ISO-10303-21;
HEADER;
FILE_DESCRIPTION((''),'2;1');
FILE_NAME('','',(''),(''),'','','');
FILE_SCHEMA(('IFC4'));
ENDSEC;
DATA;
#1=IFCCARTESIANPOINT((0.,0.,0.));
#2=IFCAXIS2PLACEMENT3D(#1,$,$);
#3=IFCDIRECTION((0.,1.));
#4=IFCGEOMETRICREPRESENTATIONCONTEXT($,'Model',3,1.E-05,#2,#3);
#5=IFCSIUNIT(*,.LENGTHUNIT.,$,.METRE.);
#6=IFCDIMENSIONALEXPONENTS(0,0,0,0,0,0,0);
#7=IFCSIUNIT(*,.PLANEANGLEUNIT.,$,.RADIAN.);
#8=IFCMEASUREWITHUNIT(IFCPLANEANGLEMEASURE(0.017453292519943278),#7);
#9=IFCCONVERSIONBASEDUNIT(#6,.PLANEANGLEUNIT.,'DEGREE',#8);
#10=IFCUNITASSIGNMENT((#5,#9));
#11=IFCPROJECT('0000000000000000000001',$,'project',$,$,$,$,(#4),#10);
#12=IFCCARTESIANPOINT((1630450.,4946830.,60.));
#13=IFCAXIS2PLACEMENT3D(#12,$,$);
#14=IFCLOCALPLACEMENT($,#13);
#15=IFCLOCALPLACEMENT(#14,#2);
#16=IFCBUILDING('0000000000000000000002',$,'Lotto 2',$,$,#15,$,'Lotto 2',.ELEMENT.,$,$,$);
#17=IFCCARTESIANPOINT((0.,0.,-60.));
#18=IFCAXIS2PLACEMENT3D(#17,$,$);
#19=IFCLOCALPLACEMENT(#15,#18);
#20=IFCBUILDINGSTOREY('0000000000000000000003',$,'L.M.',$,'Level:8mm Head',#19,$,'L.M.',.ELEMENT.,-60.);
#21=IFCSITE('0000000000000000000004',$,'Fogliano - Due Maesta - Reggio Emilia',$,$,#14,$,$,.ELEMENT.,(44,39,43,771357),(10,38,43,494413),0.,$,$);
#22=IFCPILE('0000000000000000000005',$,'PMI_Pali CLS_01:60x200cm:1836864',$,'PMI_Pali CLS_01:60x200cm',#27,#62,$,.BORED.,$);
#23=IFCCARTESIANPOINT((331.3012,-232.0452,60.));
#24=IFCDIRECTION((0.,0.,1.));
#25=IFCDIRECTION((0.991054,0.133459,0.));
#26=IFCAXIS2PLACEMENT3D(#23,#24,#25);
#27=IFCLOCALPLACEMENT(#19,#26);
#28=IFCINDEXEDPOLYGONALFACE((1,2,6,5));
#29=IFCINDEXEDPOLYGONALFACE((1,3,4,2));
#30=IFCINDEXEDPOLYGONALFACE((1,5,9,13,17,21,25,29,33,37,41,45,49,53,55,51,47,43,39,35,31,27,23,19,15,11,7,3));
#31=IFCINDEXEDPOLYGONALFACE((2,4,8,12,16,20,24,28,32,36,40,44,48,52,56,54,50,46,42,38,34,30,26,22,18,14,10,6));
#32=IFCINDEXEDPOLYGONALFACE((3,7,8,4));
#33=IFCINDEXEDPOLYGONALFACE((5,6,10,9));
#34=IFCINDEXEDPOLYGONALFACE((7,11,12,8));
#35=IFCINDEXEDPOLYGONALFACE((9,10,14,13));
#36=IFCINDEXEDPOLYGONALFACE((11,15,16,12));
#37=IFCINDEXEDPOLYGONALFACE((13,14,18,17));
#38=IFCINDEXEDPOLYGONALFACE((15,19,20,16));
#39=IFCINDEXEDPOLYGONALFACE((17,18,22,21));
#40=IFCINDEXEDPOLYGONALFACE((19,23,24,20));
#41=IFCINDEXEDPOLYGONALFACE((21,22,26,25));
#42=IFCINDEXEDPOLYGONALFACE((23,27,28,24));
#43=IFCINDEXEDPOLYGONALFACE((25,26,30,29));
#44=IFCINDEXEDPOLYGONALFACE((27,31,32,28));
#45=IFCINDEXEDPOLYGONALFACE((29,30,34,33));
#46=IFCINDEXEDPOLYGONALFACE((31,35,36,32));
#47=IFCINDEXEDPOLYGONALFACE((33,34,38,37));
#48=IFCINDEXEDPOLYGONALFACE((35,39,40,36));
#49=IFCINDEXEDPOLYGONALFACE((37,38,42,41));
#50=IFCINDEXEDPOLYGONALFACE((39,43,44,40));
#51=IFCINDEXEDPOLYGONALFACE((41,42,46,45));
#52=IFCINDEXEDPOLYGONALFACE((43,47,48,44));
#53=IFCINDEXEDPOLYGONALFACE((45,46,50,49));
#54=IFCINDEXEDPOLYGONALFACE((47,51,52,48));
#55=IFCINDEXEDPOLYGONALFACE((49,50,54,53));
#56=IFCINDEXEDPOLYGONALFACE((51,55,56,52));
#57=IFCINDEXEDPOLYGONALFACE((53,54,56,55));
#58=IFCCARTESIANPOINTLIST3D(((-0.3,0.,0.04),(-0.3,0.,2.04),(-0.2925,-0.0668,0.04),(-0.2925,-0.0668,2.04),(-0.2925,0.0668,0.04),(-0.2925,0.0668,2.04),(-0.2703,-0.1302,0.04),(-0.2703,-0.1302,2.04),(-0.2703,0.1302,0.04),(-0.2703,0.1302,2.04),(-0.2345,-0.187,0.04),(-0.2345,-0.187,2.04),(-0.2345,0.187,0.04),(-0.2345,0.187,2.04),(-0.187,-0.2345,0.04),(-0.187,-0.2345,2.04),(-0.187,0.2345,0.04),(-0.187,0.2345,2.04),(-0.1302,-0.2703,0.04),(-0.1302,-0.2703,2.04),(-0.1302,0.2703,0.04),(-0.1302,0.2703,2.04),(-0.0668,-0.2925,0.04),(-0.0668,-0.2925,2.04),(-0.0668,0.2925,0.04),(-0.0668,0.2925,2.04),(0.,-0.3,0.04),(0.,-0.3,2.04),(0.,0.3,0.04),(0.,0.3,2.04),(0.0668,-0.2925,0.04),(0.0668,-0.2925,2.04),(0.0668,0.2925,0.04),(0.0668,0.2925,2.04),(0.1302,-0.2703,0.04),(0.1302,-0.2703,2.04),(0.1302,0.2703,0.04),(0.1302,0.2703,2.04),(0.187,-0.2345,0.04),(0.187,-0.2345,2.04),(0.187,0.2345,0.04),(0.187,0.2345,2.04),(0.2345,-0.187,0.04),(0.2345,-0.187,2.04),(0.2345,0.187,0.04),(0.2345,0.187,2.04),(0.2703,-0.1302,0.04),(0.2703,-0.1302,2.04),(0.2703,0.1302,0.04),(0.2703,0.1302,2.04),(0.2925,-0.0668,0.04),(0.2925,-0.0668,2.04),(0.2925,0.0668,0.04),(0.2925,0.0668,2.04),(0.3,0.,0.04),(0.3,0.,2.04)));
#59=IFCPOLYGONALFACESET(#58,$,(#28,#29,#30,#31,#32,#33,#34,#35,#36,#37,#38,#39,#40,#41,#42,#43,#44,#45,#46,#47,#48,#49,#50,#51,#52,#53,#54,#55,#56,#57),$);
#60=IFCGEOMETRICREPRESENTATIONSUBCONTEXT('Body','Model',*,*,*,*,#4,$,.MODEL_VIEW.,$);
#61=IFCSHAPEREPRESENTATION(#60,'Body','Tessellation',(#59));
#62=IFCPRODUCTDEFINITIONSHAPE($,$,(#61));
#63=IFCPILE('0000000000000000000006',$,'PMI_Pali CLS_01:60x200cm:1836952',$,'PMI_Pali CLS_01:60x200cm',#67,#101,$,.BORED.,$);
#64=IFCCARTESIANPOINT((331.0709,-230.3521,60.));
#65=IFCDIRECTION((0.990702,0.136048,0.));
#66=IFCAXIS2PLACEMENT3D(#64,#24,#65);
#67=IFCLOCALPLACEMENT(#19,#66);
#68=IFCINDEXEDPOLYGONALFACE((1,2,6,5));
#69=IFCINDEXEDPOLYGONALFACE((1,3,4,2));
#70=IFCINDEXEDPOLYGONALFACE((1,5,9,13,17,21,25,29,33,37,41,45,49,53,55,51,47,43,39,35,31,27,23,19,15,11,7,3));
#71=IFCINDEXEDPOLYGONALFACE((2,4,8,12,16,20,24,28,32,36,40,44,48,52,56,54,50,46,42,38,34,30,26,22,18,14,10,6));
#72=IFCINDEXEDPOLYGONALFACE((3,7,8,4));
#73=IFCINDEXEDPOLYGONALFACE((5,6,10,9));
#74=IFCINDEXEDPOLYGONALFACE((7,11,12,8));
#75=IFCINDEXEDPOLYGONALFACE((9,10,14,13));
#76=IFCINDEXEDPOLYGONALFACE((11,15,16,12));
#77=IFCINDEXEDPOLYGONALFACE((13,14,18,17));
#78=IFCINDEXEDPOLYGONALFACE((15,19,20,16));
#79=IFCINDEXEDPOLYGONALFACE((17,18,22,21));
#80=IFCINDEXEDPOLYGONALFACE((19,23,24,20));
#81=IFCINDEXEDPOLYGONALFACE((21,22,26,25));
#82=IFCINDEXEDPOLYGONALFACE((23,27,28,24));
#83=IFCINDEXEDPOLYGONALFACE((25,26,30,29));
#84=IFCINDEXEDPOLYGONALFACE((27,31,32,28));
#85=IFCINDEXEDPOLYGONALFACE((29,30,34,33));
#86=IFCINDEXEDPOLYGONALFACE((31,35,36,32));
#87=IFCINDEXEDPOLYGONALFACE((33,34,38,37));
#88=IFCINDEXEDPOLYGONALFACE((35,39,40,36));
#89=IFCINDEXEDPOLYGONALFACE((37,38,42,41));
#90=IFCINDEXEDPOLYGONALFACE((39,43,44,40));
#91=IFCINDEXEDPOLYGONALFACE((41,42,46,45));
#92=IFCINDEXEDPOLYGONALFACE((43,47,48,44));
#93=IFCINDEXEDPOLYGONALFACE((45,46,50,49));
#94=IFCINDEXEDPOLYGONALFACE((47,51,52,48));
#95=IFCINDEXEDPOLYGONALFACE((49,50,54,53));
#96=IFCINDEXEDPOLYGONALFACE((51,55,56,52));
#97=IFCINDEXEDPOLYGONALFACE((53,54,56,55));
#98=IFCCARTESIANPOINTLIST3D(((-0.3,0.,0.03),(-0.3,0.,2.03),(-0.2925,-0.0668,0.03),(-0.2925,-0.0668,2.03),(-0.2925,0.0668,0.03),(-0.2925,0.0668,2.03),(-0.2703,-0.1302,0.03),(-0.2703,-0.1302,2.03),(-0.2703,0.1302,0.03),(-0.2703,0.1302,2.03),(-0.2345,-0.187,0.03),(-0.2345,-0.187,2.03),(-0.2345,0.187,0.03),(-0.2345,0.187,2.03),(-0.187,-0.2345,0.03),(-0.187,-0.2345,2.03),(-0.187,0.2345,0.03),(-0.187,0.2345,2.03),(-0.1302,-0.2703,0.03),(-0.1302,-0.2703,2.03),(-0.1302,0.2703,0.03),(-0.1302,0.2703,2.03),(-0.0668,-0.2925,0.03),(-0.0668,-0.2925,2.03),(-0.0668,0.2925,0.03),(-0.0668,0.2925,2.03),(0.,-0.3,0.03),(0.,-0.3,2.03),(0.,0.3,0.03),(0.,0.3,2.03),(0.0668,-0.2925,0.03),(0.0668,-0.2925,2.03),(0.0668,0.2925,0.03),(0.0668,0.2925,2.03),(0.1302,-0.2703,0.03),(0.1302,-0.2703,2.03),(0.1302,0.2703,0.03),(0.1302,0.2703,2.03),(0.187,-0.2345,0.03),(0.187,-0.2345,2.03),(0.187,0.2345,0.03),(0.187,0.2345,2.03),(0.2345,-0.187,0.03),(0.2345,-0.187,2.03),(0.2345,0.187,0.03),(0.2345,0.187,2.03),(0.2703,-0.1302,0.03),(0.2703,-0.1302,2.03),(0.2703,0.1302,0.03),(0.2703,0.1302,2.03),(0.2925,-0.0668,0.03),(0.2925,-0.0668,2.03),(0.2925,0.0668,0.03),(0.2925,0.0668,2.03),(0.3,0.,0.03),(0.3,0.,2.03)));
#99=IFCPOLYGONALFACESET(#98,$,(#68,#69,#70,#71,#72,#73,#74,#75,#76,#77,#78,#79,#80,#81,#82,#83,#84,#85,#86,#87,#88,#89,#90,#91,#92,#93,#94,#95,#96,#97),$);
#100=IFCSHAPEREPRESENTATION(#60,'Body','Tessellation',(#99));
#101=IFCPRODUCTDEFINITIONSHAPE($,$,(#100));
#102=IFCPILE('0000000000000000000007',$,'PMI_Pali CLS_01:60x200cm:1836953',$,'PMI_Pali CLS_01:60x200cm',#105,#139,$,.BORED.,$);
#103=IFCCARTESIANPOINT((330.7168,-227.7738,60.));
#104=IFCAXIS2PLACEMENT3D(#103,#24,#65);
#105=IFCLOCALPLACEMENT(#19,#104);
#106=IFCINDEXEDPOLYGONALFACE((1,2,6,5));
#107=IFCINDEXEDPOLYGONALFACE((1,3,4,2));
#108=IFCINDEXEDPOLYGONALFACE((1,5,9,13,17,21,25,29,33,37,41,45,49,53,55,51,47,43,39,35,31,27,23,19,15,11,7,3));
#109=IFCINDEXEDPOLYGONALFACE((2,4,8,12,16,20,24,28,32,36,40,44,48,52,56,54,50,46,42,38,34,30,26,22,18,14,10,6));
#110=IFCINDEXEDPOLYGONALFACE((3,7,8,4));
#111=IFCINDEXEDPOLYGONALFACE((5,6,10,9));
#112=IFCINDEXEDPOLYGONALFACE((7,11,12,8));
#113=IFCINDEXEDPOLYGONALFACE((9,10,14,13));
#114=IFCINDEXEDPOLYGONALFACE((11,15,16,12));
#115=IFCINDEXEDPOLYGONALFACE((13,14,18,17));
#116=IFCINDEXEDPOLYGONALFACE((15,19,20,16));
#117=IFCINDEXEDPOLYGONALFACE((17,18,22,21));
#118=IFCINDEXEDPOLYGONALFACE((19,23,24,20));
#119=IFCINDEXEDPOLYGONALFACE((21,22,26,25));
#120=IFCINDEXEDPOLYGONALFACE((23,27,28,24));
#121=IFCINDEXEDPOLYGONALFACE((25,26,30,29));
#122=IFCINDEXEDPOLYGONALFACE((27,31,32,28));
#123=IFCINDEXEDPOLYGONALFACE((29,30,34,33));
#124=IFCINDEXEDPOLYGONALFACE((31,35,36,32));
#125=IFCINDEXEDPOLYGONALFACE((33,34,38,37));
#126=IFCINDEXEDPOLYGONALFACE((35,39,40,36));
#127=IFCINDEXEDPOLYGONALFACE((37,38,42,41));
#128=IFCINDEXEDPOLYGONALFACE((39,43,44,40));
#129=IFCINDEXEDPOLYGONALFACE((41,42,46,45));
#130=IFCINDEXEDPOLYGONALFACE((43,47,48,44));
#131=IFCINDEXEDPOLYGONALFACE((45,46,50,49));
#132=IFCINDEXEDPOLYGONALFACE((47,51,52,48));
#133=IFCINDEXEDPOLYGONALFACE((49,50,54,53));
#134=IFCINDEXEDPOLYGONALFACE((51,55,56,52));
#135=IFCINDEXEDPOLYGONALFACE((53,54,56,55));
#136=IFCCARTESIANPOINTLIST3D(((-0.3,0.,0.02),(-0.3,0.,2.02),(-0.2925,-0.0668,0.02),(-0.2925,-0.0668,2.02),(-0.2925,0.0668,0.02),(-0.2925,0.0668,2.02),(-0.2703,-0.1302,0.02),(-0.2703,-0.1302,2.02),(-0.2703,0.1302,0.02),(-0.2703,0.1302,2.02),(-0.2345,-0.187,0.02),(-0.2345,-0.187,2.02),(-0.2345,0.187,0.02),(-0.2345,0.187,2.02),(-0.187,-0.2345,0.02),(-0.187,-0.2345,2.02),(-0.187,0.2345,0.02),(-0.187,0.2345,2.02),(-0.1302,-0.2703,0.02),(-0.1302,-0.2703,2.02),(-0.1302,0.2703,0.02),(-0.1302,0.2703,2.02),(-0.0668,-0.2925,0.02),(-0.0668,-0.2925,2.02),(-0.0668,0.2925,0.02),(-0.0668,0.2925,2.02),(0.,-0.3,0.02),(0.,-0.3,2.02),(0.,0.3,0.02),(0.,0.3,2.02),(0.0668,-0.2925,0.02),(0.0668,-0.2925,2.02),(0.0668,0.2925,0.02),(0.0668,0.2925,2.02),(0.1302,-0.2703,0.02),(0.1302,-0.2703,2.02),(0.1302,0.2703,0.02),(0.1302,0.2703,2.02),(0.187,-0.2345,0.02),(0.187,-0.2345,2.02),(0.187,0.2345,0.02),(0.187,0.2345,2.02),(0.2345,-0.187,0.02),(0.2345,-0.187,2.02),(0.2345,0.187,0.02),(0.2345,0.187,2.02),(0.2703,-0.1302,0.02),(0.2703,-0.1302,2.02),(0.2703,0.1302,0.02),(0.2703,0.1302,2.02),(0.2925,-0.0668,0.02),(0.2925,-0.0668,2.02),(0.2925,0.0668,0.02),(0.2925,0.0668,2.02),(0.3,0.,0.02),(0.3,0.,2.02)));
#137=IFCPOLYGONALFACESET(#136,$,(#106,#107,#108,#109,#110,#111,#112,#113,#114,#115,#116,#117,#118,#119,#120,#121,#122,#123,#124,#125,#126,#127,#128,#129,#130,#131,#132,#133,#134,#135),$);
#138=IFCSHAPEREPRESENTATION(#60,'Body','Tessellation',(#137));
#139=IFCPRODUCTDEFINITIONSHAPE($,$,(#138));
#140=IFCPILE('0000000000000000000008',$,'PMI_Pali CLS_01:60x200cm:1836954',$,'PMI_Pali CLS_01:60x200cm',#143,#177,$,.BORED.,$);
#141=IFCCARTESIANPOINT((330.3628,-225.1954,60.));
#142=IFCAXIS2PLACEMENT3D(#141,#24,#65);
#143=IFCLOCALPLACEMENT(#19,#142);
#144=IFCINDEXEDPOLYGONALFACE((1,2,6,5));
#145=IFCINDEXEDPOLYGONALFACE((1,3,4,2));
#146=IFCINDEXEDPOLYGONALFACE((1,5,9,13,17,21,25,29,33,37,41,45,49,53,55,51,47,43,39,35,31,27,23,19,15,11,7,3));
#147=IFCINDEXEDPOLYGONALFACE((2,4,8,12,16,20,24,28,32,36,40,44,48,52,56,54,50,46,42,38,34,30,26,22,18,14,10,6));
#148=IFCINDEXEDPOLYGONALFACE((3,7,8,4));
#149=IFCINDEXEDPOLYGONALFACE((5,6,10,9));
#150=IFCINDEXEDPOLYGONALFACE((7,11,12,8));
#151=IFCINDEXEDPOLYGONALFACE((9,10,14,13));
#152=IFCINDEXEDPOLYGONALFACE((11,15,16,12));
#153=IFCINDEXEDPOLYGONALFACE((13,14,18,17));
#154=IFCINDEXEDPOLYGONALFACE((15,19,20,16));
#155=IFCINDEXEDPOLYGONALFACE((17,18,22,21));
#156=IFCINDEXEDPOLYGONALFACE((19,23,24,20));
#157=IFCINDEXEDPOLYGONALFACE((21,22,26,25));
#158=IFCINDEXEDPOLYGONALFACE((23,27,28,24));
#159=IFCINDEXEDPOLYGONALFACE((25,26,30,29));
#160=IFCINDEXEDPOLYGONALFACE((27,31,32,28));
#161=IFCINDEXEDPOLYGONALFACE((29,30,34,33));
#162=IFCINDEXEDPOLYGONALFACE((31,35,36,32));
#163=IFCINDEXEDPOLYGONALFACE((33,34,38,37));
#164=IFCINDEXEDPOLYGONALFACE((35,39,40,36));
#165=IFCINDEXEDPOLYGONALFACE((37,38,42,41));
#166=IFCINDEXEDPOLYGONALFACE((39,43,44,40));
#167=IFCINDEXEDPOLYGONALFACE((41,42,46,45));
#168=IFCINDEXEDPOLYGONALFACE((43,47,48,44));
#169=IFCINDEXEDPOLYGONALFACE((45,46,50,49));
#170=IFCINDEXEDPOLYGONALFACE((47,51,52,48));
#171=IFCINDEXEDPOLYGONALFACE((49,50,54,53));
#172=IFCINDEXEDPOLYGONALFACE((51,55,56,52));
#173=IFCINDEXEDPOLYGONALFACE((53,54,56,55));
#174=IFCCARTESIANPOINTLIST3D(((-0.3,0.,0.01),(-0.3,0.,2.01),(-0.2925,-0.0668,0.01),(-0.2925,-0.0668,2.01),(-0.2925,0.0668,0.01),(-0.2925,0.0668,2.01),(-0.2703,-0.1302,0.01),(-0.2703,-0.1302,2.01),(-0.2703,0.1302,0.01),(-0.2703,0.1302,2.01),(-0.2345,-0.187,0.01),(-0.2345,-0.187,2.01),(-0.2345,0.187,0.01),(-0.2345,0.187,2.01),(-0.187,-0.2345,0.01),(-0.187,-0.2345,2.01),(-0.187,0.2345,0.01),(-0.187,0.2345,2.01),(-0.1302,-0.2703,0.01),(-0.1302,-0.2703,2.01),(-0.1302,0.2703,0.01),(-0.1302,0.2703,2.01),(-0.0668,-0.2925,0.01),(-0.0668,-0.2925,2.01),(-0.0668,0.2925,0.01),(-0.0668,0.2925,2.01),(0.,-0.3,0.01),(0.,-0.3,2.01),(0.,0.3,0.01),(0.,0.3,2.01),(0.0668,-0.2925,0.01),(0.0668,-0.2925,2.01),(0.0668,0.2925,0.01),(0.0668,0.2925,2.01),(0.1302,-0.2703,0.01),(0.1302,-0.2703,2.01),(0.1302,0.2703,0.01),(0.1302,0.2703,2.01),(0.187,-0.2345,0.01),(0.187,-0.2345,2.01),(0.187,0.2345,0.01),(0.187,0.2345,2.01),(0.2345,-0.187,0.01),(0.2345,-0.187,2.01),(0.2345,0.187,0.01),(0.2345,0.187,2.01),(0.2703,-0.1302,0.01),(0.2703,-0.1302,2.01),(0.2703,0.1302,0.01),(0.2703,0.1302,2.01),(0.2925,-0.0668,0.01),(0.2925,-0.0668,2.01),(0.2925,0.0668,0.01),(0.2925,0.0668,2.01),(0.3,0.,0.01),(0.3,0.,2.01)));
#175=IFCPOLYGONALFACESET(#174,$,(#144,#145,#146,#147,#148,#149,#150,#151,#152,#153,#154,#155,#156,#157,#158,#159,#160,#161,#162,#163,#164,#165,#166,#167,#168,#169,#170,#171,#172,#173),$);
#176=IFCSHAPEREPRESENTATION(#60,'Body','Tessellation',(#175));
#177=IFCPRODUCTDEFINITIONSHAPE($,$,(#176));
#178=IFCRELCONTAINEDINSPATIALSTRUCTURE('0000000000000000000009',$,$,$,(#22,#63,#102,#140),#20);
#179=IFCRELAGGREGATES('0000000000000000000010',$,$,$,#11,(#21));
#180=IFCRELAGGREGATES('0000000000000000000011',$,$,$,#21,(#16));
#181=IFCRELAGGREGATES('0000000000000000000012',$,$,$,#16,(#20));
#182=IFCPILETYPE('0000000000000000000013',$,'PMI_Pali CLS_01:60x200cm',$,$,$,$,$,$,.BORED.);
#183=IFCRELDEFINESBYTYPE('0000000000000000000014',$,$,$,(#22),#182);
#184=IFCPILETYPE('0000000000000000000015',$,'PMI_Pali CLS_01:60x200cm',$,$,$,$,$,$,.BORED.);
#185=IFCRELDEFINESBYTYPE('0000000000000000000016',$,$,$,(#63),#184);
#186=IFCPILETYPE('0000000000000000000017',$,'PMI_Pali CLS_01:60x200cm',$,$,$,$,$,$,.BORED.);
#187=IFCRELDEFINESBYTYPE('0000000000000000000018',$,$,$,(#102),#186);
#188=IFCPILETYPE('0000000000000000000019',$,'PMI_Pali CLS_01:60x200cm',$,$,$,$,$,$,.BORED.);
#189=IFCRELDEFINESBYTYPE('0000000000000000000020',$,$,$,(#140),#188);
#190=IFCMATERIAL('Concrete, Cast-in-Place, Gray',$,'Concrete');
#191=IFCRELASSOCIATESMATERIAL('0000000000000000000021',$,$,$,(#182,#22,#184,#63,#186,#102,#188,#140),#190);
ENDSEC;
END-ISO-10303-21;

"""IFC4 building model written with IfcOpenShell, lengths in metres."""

from ifc_helpers import new_model, entity, si_unit, converted_unit, direction, frame, origin, place, context, subcontext, project, spatial, arc, indexed_curve, outline, extrude, source, transform, mapped, material, type_object, type_shapes, element, save


model = new_model("IFC4")

# Units and contexts
model_context = context("Model", 3, precision=1e-05, world=origin(), true_north=direction((0.0, 1.0)))
body_context = subcontext(model_context, "Body", "Model", "MODEL_VIEW")
ifc_project = project(units=[si_unit("LENGTHUNIT", "METRE"), converted_unit("PLANEANGLEUNIT", "DEGREE", entity("IfcPlaneAngleMeasure", 0.017453292519943278), si_unit("PLANEANGLEUNIT", "RADIAN"), dimensions=[0, 0, 0, 0, 0, 0, 0])], contexts=[model_context])

# Site, building, storey
site_placement = place(None, frame((1630450.0, 4946830.0, 60.0)))
site = spatial("IfcSite", under=ifc_project, at=site_placement, Name="Fogliano - Due Maesta - Reggio Emilia", CompositionType="ELEMENT", RefLatitude=(44, 39, 43, 771357), RefLongitude=(10, 38, 43, 494413), RefElevation=0.0)
building_placement = place(site_placement, origin())
building = spatial("IfcBuilding", under=site, at=building_placement, Name="Lotto 2", LongName="Lotto 2", CompositionType="ELEMENT")
storey_placement = place(building_placement, frame((0.0, 0.0, -60.0)))
storey = spatial("IfcBuildingStorey", under=building, at=storey_placement, Name="L.M.", ObjectType="Level:8mm Head", LongName="L.M.", CompositionType="ELEMENT", Elevation=-60.0)

# Piles
ifc_material_1 = material(Name="Concrete, Cast-in-Place, Gray", Category="Concrete")
pile_type_1 = type_object("IfcPileType", Name="PMI_Pali CLS_01:60x200cm", PredefinedType="BORED", material=ifc_material_1)
shared_shape_1 = source(origin(), body_context, "Body", "SweptSolid", [
    extrude(outline(indexed_curve([(-0.3, 0.0), (0.0, -0.3), (0.3, 0.0), (0.0, 0.3)], segments=[arc(1, 2, 3), arc(3, 4, 1)], self_intersect=False)), frame((0.0, 0.0, 0.04)), (0.0, 0.0, 1.0), 2.0),
])
type_shapes(pile_type_1, [shared_shape_1])
pile_1_placement = place(storey_placement, frame((331.3012, -232.0452, 60.0), z_axis=(0.0, 0.0, 1.0), x_axis=(0.991054, 0.133459, 0.0)))
element("IfcPile", 1, at=pile_1_placement, inside=storey, type_object=pile_type_1, material=ifc_material_1, Name="PMI_Pali CLS_01:60x200cm:1836864", ObjectType="PMI_Pali CLS_01:60x200cm", PredefinedType="BORED", context=body_context, shape_type="MappedRepresentation", body=[
    mapped(shared_shape_1, transform((0.0, 0.0, 0.0), scale=1.0)),
])
pile_type_2 = type_object("IfcPileType", Name="PMI_Pali CLS_01:60x200cm", PredefinedType="BORED", material=ifc_material_1)
shared_shape_2 = source(origin(), body_context, "Body", "SweptSolid", [
    extrude(outline(indexed_curve([(-0.3, 0.0), (0.0, -0.3), (0.3, 0.0), (0.0, 0.3)], segments=[arc(1, 2, 3), arc(3, 4, 1)], self_intersect=False)), frame((0.0, 0.0, 0.03)), (0.0, 0.0, 1.0), 2.0),
])
type_shapes(pile_type_2, [shared_shape_2])
pile_2_placement = place(storey_placement, frame((331.0709, -230.3521, 60.0), z_axis=(0.0, 0.0, 1.0), x_axis=(0.990702, 0.136048, 0.0)))
element("IfcPile", 2, at=pile_2_placement, inside=storey, type_object=pile_type_2, material=ifc_material_1, Name="PMI_Pali CLS_01:60x200cm:1836952", ObjectType="PMI_Pali CLS_01:60x200cm", PredefinedType="BORED", context=body_context, shape_type="MappedRepresentation", body=[
    mapped(shared_shape_2, transform((0.0, 0.0, 0.0), scale=1.0)),
])
pile_type_3 = type_object("IfcPileType", Name="PMI_Pali CLS_01:60x200cm", PredefinedType="BORED", material=ifc_material_1)
shared_shape_3 = source(origin(), body_context, "Body", "SweptSolid", [
    extrude(outline(indexed_curve([(-0.3, 0.0), (0.0, -0.3), (0.3, 0.0), (0.0, 0.3)], segments=[arc(1, 2, 3), arc(3, 4, 1)], self_intersect=False)), frame((0.0, 0.0, 0.02)), (0.0, 0.0, 1.0), 2.0),
])
type_shapes(pile_type_3, [shared_shape_3])
pile_3_placement = place(storey_placement, frame((330.7168, -227.7738, 60.0), z_axis=(0.0, 0.0, 1.0), x_axis=(0.990702, 0.136048, 0.0)))
element("IfcPile", 3, at=pile_3_placement, inside=storey, type_object=pile_type_3, material=ifc_material_1, Name="PMI_Pali CLS_01:60x200cm:1836953", ObjectType="PMI_Pali CLS_01:60x200cm", PredefinedType="BORED", context=body_context, shape_type="MappedRepresentation", body=[
    mapped(shared_shape_3, transform((0.0, 0.0, 0.0), scale=1.0)),
])
pile_type_4 = type_object("IfcPileType", Name="PMI_Pali CLS_01:60x200cm", PredefinedType="BORED", material=ifc_material_1)
shared_shape_4 = source(origin(), body_context, "Body", "SweptSolid", [
    extrude(outline(indexed_curve([(-0.3, 0.0), (0.0, -0.3), (0.3, 0.0), (0.0, 0.3)], segments=[arc(1, 2, 3), arc(3, 4, 1)], self_intersect=False)), frame((0.0, 0.0, 0.01)), (0.0, 0.0, 1.0), 2.0),
])
type_shapes(pile_type_4, [shared_shape_4])
pile_4_placement = place(storey_placement, frame((330.3628, -225.1954, 60.0), z_axis=(0.0, 0.0, 1.0), x_axis=(0.990702, 0.136048, 0.0)))
element("IfcPile", 4, at=pile_4_placement, inside=storey, type_object=pile_type_4, material=ifc_material_1, Name="PMI_Pali CLS_01:60x200cm:1836954", ObjectType="PMI_Pali CLS_01:60x200cm", PredefinedType="BORED", context=body_context, shape_type="MappedRepresentation", body=[
    mapped(shared_shape_4, transform((0.0, 0.0, 0.0), scale=1.0)),
])

save(model, "model.ifc")
